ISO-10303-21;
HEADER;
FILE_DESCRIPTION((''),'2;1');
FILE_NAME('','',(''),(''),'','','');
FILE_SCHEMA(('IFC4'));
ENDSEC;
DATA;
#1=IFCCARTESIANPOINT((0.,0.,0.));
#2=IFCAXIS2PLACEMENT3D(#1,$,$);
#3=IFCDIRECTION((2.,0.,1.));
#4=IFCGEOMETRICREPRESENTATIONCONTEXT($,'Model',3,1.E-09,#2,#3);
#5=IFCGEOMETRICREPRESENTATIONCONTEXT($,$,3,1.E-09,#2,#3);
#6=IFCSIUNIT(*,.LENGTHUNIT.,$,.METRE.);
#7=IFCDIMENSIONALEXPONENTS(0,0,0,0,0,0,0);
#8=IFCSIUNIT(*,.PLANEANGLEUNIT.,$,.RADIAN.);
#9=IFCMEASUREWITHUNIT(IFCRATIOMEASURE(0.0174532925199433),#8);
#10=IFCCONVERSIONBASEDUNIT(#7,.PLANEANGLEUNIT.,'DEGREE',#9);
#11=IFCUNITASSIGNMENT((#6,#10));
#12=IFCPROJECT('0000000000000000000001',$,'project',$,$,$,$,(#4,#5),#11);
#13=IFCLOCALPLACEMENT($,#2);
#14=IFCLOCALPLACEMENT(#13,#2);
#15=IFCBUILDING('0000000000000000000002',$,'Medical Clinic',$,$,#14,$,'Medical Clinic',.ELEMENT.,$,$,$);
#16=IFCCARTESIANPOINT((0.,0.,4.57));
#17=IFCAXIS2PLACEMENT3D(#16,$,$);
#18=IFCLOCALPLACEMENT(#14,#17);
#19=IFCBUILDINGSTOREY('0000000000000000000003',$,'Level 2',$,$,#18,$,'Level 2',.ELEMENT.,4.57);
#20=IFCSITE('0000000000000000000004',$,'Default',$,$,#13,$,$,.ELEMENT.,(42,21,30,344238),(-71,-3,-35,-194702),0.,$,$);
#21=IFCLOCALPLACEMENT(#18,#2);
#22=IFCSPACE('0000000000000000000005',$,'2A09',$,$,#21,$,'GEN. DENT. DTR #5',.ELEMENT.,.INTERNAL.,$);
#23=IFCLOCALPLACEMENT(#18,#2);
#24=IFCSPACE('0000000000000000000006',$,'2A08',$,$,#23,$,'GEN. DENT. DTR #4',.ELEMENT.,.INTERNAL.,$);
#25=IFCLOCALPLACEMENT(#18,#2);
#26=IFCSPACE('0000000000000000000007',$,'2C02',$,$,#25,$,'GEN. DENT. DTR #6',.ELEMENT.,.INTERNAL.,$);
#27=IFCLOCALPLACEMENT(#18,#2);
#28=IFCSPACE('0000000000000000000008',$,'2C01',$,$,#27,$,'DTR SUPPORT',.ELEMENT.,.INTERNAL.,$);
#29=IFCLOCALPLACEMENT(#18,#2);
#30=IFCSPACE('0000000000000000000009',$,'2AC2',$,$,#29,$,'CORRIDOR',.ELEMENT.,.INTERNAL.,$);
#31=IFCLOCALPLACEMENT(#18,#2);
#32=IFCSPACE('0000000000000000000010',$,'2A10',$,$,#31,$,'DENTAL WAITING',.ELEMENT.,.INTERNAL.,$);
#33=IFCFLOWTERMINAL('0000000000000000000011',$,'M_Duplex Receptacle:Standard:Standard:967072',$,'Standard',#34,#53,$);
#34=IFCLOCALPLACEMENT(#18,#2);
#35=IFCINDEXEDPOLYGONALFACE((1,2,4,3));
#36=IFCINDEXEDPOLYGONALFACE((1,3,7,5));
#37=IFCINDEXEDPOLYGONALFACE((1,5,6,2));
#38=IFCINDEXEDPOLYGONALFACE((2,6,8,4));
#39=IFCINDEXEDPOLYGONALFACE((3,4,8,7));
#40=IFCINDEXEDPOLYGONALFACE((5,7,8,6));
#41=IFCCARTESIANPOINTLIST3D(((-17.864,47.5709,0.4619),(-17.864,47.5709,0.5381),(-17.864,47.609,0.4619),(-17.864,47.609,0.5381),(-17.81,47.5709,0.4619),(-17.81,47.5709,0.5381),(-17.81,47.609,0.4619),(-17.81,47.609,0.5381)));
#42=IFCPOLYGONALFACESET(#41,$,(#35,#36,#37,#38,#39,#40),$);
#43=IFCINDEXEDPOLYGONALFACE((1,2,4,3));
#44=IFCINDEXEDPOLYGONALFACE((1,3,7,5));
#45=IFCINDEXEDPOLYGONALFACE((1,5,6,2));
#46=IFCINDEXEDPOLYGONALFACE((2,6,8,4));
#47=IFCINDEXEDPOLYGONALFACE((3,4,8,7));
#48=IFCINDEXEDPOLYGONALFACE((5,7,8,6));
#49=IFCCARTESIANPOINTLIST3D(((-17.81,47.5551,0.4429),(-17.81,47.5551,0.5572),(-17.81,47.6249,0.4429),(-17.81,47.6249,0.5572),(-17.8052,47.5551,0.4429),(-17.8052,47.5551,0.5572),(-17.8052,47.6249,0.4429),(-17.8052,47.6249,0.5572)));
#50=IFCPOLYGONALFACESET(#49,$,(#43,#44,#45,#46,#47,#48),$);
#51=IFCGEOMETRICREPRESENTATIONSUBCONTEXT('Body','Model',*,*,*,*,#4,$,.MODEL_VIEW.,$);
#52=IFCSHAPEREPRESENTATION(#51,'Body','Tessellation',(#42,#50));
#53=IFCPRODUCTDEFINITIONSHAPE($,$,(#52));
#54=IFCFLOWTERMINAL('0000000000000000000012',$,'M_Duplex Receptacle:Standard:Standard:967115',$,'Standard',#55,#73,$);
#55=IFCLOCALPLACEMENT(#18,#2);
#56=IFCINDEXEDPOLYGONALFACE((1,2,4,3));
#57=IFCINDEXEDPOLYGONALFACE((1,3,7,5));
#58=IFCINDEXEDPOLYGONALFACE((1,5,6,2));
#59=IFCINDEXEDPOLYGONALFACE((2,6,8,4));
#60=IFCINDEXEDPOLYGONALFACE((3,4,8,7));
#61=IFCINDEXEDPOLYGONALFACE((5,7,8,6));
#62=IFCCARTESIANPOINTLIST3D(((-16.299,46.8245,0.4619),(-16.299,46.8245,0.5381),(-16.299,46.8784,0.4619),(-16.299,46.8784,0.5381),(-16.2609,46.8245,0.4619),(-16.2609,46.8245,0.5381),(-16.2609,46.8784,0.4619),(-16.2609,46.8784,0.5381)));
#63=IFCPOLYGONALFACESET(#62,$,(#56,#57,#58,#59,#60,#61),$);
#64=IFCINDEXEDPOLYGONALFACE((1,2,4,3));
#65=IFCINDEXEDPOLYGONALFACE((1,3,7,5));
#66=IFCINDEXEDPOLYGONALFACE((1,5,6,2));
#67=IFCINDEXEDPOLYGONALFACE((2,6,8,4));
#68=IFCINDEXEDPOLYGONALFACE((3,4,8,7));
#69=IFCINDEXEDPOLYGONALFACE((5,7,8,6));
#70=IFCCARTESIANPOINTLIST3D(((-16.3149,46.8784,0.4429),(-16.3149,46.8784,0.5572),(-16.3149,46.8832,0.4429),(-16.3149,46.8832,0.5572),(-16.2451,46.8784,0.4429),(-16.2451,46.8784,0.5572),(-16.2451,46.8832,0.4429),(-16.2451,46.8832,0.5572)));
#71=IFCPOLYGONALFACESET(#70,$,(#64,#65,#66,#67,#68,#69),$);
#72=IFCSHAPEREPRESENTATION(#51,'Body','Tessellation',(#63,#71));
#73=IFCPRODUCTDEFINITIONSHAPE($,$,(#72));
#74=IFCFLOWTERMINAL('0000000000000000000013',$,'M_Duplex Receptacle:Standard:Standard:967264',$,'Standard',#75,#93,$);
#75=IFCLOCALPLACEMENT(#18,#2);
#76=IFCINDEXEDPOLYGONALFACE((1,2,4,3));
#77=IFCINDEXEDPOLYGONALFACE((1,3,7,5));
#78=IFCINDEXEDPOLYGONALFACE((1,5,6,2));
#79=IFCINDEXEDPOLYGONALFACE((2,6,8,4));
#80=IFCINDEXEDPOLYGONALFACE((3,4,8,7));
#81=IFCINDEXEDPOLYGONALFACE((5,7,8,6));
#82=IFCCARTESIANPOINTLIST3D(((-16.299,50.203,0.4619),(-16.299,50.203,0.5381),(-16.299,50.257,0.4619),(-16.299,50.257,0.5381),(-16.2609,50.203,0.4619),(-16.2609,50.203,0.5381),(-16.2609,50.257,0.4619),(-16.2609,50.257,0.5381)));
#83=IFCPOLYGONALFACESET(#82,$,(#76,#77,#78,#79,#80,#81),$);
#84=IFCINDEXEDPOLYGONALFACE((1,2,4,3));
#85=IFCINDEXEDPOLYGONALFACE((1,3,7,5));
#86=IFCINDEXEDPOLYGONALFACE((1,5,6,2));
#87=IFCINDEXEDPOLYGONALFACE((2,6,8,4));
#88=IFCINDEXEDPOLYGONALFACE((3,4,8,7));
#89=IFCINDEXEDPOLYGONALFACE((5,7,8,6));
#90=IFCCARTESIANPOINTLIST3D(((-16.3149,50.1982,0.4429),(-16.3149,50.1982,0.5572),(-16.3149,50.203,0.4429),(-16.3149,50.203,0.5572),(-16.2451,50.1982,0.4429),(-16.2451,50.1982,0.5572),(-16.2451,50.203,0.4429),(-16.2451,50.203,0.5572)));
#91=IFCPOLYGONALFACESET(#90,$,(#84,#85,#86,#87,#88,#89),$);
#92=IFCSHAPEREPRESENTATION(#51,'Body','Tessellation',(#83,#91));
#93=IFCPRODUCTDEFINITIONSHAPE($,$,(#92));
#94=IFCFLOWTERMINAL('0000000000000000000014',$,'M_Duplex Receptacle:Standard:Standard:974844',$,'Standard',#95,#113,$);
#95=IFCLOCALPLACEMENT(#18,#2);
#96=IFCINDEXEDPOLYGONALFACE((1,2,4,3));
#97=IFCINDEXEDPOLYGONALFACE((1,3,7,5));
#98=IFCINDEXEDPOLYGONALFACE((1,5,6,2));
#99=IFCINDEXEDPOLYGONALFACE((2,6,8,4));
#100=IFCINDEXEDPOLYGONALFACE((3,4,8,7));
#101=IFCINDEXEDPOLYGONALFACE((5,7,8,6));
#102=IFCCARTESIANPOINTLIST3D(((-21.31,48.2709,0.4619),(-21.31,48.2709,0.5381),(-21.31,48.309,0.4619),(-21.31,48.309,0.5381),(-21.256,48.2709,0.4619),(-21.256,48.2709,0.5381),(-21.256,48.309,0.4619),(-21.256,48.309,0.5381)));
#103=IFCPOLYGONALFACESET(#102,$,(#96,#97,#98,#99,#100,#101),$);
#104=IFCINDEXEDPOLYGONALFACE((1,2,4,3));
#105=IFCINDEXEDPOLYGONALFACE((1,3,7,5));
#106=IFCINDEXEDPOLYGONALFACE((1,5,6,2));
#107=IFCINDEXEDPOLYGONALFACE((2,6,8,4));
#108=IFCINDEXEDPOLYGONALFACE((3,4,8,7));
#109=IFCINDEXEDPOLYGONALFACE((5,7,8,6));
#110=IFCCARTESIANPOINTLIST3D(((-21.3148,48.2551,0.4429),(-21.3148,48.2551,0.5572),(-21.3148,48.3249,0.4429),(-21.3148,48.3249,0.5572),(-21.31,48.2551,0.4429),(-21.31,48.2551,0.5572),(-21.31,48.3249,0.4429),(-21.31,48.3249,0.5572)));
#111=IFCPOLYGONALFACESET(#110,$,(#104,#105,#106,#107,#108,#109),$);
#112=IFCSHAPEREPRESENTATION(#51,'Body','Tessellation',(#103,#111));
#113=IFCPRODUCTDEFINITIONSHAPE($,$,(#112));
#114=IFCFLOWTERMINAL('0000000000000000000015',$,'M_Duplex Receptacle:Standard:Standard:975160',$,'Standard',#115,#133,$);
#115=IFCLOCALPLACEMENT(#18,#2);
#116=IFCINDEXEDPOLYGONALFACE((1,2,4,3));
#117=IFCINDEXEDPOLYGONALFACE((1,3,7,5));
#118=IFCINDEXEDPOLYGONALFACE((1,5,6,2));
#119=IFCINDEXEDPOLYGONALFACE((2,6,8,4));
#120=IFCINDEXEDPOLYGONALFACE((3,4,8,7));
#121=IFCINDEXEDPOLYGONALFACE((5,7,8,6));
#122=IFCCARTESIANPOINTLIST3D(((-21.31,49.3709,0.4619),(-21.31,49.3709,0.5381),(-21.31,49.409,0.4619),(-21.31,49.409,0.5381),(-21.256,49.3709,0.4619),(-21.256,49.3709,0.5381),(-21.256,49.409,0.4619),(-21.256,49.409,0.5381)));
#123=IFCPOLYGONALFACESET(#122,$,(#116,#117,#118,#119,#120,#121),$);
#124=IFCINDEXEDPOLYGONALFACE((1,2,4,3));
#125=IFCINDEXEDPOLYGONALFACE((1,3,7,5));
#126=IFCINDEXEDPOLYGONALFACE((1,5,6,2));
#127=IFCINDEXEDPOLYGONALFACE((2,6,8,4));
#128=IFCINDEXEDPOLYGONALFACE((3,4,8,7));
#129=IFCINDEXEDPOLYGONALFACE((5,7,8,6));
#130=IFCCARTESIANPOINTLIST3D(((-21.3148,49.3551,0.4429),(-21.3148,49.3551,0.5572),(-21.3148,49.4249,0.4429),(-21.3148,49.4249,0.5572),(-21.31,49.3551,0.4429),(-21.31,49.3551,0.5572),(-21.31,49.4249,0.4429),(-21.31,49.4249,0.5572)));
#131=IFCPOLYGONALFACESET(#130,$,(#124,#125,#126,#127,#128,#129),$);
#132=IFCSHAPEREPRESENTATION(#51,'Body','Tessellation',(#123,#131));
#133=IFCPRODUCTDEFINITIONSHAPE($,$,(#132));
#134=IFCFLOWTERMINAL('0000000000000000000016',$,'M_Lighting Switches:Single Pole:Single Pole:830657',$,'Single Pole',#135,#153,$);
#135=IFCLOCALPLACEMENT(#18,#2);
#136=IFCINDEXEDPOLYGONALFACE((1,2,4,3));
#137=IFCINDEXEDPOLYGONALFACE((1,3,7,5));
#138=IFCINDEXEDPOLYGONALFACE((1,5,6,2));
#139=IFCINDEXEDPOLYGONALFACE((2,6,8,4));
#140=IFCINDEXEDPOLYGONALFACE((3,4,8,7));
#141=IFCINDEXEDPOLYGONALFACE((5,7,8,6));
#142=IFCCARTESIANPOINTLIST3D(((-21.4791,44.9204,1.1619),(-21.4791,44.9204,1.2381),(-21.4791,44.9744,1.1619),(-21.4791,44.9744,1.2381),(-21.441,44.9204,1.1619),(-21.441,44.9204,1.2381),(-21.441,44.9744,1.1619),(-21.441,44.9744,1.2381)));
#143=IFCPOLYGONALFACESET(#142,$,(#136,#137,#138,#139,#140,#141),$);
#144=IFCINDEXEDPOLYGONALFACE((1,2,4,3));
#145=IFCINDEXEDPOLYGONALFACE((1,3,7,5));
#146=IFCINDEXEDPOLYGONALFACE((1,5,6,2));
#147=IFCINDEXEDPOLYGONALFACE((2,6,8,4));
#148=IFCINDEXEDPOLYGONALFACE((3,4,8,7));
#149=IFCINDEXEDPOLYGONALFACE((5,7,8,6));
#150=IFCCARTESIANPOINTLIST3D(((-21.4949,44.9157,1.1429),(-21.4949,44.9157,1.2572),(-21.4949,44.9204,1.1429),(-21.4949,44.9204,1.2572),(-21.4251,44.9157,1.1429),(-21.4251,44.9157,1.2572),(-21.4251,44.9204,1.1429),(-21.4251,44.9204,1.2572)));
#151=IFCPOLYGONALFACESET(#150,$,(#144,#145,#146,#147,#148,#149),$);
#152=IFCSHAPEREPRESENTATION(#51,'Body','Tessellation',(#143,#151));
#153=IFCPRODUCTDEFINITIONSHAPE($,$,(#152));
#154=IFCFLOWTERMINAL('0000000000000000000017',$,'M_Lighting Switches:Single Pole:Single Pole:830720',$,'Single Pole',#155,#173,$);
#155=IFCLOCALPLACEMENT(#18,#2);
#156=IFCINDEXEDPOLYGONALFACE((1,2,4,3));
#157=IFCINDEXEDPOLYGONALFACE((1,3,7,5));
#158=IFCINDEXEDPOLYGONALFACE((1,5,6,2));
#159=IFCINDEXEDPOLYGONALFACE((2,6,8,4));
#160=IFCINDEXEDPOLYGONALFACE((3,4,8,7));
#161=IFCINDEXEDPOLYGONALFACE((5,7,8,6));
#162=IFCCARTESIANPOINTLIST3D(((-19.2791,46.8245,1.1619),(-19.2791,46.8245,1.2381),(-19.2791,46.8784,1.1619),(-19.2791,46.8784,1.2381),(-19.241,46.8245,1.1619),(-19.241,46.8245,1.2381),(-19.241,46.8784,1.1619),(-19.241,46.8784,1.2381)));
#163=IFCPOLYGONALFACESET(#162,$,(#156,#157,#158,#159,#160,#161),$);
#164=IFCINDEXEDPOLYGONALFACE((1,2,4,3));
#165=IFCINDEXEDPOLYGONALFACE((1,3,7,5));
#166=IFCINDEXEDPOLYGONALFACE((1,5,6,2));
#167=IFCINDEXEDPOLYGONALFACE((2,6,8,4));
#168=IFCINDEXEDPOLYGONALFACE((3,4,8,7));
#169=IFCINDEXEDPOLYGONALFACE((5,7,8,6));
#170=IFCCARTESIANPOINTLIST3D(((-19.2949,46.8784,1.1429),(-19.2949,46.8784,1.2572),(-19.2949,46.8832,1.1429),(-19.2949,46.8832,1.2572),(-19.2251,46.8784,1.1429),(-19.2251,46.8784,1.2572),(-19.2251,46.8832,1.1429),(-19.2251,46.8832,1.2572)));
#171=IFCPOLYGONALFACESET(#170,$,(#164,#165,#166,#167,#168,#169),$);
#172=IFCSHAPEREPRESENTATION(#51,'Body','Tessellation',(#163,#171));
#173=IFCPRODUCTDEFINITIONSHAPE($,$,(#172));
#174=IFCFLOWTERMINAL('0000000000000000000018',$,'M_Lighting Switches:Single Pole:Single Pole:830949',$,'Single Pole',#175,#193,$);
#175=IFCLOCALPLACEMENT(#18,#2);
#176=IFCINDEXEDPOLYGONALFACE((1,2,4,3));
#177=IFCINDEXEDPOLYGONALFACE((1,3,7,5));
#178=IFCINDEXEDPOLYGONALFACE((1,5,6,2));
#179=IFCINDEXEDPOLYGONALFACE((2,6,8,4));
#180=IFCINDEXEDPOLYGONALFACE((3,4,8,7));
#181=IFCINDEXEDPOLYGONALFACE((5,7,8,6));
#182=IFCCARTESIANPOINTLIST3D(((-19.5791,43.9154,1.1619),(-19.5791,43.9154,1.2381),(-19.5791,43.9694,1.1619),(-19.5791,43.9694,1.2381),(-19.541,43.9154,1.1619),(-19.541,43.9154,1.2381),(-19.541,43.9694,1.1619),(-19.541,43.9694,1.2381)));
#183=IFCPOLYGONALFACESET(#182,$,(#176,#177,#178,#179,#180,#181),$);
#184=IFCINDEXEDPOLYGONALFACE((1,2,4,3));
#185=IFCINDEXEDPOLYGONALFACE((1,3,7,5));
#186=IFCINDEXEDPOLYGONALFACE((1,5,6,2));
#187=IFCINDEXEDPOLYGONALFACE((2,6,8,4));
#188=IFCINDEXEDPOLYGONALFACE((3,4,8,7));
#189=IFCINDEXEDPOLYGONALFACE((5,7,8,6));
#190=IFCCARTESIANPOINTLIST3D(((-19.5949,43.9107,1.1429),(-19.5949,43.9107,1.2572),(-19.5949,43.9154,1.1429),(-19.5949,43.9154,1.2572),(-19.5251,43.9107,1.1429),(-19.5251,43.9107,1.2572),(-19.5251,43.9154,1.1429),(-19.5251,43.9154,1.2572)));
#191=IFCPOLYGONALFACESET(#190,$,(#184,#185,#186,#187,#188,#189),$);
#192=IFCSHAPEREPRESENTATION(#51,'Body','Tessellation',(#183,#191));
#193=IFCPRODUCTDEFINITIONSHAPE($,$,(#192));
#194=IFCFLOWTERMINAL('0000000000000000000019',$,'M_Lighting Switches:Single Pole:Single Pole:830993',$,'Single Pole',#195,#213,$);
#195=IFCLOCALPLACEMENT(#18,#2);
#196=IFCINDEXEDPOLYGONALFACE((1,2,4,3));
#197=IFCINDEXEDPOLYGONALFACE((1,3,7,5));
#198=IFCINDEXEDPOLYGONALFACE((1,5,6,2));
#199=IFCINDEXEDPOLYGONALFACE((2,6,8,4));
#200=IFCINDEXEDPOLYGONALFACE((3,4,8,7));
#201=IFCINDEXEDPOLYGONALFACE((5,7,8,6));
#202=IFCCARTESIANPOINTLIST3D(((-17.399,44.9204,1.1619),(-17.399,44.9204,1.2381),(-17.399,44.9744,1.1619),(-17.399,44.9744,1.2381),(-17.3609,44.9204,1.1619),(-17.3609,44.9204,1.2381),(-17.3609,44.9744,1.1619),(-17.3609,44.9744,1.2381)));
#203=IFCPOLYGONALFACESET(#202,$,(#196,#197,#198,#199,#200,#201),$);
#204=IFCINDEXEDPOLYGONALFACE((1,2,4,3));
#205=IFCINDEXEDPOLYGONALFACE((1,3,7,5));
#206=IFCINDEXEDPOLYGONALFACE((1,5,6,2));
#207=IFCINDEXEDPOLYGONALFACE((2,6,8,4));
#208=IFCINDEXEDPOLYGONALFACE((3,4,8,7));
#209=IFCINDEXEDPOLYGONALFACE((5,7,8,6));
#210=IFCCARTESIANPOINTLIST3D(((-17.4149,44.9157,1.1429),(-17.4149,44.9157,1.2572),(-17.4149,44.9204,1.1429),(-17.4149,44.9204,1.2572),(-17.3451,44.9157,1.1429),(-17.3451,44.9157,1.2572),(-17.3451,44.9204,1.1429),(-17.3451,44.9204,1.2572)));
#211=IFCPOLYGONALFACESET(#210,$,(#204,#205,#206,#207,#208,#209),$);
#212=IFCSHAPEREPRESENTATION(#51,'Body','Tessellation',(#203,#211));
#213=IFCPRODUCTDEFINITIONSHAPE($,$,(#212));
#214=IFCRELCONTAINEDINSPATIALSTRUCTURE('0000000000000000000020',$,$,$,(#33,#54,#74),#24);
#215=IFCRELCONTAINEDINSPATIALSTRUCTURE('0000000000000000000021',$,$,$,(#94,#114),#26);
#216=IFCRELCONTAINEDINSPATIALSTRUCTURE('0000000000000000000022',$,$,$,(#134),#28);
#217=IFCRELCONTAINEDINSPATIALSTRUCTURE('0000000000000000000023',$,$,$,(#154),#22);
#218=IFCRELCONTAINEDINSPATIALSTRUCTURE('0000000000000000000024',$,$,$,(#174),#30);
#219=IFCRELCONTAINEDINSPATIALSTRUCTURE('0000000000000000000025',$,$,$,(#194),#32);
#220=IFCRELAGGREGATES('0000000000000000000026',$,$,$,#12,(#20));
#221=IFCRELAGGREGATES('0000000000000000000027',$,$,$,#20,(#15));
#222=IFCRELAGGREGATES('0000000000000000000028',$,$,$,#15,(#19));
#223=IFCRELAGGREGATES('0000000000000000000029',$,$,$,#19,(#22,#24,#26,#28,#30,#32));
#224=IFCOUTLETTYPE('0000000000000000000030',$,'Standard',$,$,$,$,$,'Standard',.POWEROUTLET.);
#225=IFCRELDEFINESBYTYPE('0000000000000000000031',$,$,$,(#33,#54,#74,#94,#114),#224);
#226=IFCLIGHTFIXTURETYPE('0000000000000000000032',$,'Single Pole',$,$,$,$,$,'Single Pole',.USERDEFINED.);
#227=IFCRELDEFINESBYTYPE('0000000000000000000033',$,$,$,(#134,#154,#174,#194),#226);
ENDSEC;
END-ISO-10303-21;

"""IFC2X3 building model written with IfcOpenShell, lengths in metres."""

from ifc_helpers import new_model, entity, si_unit, converted_unit, direction, frame, frame_2d, origin, origin_2d_with_axis, place, context, subcontext, project, spatial, rectangle, extrude, source, transform, mapped, type_object, type_shapes, element, save


model = new_model("IFC2X3")

# Units and contexts
model_context = context("Model", 3, precision=1e-09, world=origin(), true_north=direction((2.0, 0.0, 1.0)))
context_of_model = context(None, 3, precision=1e-09, world=origin(), true_north=direction((2.0, 0.0, 1.0)))
body_context = subcontext(model_context, "Body", "Model", "MODEL_VIEW")
ifc_project = project(units=[si_unit("LENGTHUNIT", "METRE"), converted_unit("PLANEANGLEUNIT", "DEGREE", entity("IfcRatioMeasure", 0.0174532925199433), si_unit("PLANEANGLEUNIT", "RADIAN"), dimensions=[0, 0, 0, 0, 0, 0, 0])], contexts=[model_context, context_of_model])

# Site, building, storey, space
site_placement = place(None, origin())
site = spatial("IfcSite", under=ifc_project, at=site_placement, Name="Default", CompositionType="ELEMENT", RefLatitude=(42, 21, 30, 344238), RefLongitude=(-71, -3, -35, -194702), RefElevation=0.0)
building_placement = place(site_placement, origin())
building = spatial("IfcBuilding", under=site, at=building_placement, Name="Medical Clinic", LongName="Medical Clinic", CompositionType="ELEMENT")
storey_placement = place(building_placement, frame((0.0, 0.0, 4.57)))
storey = spatial("IfcBuildingStorey", under=building, at=storey_placement, Name="Level 2", LongName="Level 2", CompositionType="ELEMENT", Elevation=4.57)
space_1_placement = place(storey_placement, origin())
space_1 = spatial("IfcSpace", under=storey, at=space_1_placement, Name="2A09", LongName="GEN. DENT. DTR #5", CompositionType="ELEMENT", InteriorOrExteriorSpace="INTERNAL")

# Shared definitions
outlet_type = type_object("IfcOutletType", Name="Standard", ElementType="Standard", PredefinedType="POWEROUTLET")
shared_shape_1 = source(origin(), body_context, "Body", "SweptSolid", [
    extrude(rectangle(XDim=0.0381, YDim=0.0762, at=origin_2d_with_axis()), frame((0.0, 0.0, -0.054), z_axis=(0.0, 0.0, 1.0), x_axis=(-1.0, 0.0, 0.0)), (0.0, 0.0, 1.0), 0.054),
    extrude(rectangle(XDim=0.0698, YDim=0.1143, at=frame_2d((0.0, 0.0), x_axis=(1.0, 0.0))), frame((0.0, 0.0, 0.0), z_axis=(0.0, 0.0, 1.0), x_axis=(-1.0, 0.0, 0.0)), (0.0, 0.0, 1.0), 0.0048),
])
type_shapes(outlet_type, [shared_shape_1])

# Shared definitions
space_2_placement = place(storey_placement, origin())
space_2 = spatial("IfcSpace", under=storey, at=space_2_placement, Name="2A08", LongName="GEN. DENT. DTR #4", CompositionType="ELEMENT", InteriorOrExteriorSpace="INTERNAL")

# Flow terminals
for number, where, z_axis, x_axis, name in (
    (1, (-17.81, 47.59, 0.5), (1.0, 0.0, 0.0), (0.0, 1.0, 0.0), "M_Duplex Receptacle:Standard:Standard:967072"),
    (2, (-16.28, 46.8784, 0.5), (0.0, 1.0, 0.0), (-1.0, 0.0, 0.0), "M_Duplex Receptacle:Standard:Standard:967115"),
    (3, (-16.28, 50.203, 0.5), (0.0, -1.0, 0.0), (1.0, 0.0, 0.0), "M_Duplex Receptacle:Standard:Standard:967264"),
):
    element("IfcFlowTerminal", number, at=place(space_2_placement, frame(where, z_axis=z_axis, x_axis=x_axis)), inside=space_2, type_object=outlet_type, Name=name, ObjectType="Standard", context=body_context, shape_type="MappedRepresentation", body=[
        mapped(shared_shape_1, transform((0.0, 0.0, 0.0), scale=1.0)),
    ])

# Shared definitions
space_3_placement = place(storey_placement, origin())
space_3 = spatial("IfcSpace", under=storey, at=space_3_placement, Name="2C02", LongName="GEN. DENT. DTR #6", CompositionType="ELEMENT", InteriorOrExteriorSpace="INTERNAL")

# Flow terminals
for number, where, z_axis, x_axis, name in (
    (4, (-21.31, 48.29, 0.5), (-1.0, 0.0, 0.0), (0.0, -1.0, 0.0), "M_Duplex Receptacle:Standard:Standard:974844"),
    (5, (-21.31, 49.39, 0.5), (-1.0, 0.0, 0.0), (0.0, -1.0, 0.0), "M_Duplex Receptacle:Standard:Standard:975160"),
):
    element("IfcFlowTerminal", number, at=place(space_3_placement, frame(where, z_axis=z_axis, x_axis=x_axis)), inside=space_3, type_object=outlet_type, Name=name, ObjectType="Standard", context=body_context, shape_type="MappedRepresentation", body=[
        mapped(shared_shape_1, transform((0.0, 0.0, 0.0), scale=1.0)),
    ])

# Shared definitions
space_4_placement = place(storey_placement, origin())
space_4 = spatial("IfcSpace", under=storey, at=space_4_placement, Name="2C01", LongName="DTR SUPPORT", CompositionType="ELEMENT", InteriorOrExteriorSpace="INTERNAL")

# Flow terminals
light_fixture_type_1 = type_object("IfcLightFixtureType", Name="Single Pole", ElementType="Single Pole", PredefinedType="USERDEFINED")
shared_shape_2 = source(origin(), body_context, "Body", "SweptSolid", [
    extrude(rectangle(XDim=0.0381, YDim=0.0762, at=origin_2d_with_axis()), frame((0.0, 0.0, -0.054), z_axis=(0.0, 0.0, 1.0), x_axis=(-1.0, 0.0, 0.0)), (0.0, 0.0, 1.0), 0.054),
    extrude(rectangle(XDim=0.0698, YDim=0.1143, at=frame_2d((0.0, 0.0), x_axis=(1.0, 0.0))), frame((0.0, 0.0, 0.0), z_axis=(0.0, 0.0, 1.0), x_axis=(-1.0, 0.0, 0.0)), (0.0, 0.0, 1.0), 0.0048),
])
type_shapes(light_fixture_type_1, [shared_shape_2])
flow_terminal_1_placement = place(space_4_placement, frame((-21.46, 44.9204, 1.2), z_axis=(0.0, -1.0, 0.0), x_axis=(1.0, 0.0, 0.0)))
element("IfcFlowTerminal", 6, at=flow_terminal_1_placement, inside=space_4, type_object=light_fixture_type_1, Name="M_Lighting Switches:Single Pole:Single Pole:830657", ObjectType="Single Pole", context=body_context, shape_type="MappedRepresentation", body=[
    mapped(shared_shape_2, transform((0.0, 0.0, 0.0), scale=1.0)),
])
flow_terminal_2_placement = place(space_1_placement, frame((-19.26, 46.8784, 1.2), z_axis=(0.0, 1.0, 0.0), x_axis=(-1.0, 0.0, 0.0)))
element("IfcFlowTerminal", 7, at=flow_terminal_2_placement, inside=space_1, type_object=light_fixture_type_1, Name="M_Lighting Switches:Single Pole:Single Pole:830720", ObjectType="Single Pole", context=body_context, shape_type="MappedRepresentation", body=[
    mapped(shared_shape_2, transform((0.0, 0.0, 0.0), scale=1.0)),
])

# Shared definitions
space_5_placement = place(storey_placement, origin())
space_5 = spatial("IfcSpace", under=storey, at=space_5_placement, Name="2AC2", LongName="CORRIDOR", CompositionType="ELEMENT", InteriorOrExteriorSpace="INTERNAL")

# Flow terminal
flow_terminal_3_placement = place(space_5_placement, frame((-19.56, 43.9154, 1.2), z_axis=(0.0, -1.0, 0.0), x_axis=(1.0, 0.0, 0.0)))
element("IfcFlowTerminal", 8, at=flow_terminal_3_placement, inside=space_5, type_object=light_fixture_type_1, Name="M_Lighting Switches:Single Pole:Single Pole:830949", ObjectType="Single Pole", context=body_context, shape_type="MappedRepresentation", body=[
    mapped(shared_shape_2, transform((0.0, 0.0, 0.0), scale=1.0)),
])

# Shared definitions
space_6_placement = place(storey_placement, origin())
space_6 = spatial("IfcSpace", under=storey, at=space_6_placement, Name="2A10", LongName="DENTAL WAITING", CompositionType="ELEMENT", InteriorOrExteriorSpace="INTERNAL")

# Flow terminal
flow_terminal_4_placement = place(space_6_placement, frame((-17.38, 44.9204, 1.2), z_axis=(0.0, -1.0, 0.0), x_axis=(1.0, 0.0, 0.0)))
element("IfcFlowTerminal", 9, at=flow_terminal_4_placement, inside=space_6, type_object=light_fixture_type_1, Name="M_Lighting Switches:Single Pole:Single Pole:830993", ObjectType="Single Pole", context=body_context, shape_type="MappedRepresentation", body=[
    mapped(shared_shape_2, transform((0.0, 0.0, 0.0), scale=1.0)),
])

save(model, "model.ifc")
